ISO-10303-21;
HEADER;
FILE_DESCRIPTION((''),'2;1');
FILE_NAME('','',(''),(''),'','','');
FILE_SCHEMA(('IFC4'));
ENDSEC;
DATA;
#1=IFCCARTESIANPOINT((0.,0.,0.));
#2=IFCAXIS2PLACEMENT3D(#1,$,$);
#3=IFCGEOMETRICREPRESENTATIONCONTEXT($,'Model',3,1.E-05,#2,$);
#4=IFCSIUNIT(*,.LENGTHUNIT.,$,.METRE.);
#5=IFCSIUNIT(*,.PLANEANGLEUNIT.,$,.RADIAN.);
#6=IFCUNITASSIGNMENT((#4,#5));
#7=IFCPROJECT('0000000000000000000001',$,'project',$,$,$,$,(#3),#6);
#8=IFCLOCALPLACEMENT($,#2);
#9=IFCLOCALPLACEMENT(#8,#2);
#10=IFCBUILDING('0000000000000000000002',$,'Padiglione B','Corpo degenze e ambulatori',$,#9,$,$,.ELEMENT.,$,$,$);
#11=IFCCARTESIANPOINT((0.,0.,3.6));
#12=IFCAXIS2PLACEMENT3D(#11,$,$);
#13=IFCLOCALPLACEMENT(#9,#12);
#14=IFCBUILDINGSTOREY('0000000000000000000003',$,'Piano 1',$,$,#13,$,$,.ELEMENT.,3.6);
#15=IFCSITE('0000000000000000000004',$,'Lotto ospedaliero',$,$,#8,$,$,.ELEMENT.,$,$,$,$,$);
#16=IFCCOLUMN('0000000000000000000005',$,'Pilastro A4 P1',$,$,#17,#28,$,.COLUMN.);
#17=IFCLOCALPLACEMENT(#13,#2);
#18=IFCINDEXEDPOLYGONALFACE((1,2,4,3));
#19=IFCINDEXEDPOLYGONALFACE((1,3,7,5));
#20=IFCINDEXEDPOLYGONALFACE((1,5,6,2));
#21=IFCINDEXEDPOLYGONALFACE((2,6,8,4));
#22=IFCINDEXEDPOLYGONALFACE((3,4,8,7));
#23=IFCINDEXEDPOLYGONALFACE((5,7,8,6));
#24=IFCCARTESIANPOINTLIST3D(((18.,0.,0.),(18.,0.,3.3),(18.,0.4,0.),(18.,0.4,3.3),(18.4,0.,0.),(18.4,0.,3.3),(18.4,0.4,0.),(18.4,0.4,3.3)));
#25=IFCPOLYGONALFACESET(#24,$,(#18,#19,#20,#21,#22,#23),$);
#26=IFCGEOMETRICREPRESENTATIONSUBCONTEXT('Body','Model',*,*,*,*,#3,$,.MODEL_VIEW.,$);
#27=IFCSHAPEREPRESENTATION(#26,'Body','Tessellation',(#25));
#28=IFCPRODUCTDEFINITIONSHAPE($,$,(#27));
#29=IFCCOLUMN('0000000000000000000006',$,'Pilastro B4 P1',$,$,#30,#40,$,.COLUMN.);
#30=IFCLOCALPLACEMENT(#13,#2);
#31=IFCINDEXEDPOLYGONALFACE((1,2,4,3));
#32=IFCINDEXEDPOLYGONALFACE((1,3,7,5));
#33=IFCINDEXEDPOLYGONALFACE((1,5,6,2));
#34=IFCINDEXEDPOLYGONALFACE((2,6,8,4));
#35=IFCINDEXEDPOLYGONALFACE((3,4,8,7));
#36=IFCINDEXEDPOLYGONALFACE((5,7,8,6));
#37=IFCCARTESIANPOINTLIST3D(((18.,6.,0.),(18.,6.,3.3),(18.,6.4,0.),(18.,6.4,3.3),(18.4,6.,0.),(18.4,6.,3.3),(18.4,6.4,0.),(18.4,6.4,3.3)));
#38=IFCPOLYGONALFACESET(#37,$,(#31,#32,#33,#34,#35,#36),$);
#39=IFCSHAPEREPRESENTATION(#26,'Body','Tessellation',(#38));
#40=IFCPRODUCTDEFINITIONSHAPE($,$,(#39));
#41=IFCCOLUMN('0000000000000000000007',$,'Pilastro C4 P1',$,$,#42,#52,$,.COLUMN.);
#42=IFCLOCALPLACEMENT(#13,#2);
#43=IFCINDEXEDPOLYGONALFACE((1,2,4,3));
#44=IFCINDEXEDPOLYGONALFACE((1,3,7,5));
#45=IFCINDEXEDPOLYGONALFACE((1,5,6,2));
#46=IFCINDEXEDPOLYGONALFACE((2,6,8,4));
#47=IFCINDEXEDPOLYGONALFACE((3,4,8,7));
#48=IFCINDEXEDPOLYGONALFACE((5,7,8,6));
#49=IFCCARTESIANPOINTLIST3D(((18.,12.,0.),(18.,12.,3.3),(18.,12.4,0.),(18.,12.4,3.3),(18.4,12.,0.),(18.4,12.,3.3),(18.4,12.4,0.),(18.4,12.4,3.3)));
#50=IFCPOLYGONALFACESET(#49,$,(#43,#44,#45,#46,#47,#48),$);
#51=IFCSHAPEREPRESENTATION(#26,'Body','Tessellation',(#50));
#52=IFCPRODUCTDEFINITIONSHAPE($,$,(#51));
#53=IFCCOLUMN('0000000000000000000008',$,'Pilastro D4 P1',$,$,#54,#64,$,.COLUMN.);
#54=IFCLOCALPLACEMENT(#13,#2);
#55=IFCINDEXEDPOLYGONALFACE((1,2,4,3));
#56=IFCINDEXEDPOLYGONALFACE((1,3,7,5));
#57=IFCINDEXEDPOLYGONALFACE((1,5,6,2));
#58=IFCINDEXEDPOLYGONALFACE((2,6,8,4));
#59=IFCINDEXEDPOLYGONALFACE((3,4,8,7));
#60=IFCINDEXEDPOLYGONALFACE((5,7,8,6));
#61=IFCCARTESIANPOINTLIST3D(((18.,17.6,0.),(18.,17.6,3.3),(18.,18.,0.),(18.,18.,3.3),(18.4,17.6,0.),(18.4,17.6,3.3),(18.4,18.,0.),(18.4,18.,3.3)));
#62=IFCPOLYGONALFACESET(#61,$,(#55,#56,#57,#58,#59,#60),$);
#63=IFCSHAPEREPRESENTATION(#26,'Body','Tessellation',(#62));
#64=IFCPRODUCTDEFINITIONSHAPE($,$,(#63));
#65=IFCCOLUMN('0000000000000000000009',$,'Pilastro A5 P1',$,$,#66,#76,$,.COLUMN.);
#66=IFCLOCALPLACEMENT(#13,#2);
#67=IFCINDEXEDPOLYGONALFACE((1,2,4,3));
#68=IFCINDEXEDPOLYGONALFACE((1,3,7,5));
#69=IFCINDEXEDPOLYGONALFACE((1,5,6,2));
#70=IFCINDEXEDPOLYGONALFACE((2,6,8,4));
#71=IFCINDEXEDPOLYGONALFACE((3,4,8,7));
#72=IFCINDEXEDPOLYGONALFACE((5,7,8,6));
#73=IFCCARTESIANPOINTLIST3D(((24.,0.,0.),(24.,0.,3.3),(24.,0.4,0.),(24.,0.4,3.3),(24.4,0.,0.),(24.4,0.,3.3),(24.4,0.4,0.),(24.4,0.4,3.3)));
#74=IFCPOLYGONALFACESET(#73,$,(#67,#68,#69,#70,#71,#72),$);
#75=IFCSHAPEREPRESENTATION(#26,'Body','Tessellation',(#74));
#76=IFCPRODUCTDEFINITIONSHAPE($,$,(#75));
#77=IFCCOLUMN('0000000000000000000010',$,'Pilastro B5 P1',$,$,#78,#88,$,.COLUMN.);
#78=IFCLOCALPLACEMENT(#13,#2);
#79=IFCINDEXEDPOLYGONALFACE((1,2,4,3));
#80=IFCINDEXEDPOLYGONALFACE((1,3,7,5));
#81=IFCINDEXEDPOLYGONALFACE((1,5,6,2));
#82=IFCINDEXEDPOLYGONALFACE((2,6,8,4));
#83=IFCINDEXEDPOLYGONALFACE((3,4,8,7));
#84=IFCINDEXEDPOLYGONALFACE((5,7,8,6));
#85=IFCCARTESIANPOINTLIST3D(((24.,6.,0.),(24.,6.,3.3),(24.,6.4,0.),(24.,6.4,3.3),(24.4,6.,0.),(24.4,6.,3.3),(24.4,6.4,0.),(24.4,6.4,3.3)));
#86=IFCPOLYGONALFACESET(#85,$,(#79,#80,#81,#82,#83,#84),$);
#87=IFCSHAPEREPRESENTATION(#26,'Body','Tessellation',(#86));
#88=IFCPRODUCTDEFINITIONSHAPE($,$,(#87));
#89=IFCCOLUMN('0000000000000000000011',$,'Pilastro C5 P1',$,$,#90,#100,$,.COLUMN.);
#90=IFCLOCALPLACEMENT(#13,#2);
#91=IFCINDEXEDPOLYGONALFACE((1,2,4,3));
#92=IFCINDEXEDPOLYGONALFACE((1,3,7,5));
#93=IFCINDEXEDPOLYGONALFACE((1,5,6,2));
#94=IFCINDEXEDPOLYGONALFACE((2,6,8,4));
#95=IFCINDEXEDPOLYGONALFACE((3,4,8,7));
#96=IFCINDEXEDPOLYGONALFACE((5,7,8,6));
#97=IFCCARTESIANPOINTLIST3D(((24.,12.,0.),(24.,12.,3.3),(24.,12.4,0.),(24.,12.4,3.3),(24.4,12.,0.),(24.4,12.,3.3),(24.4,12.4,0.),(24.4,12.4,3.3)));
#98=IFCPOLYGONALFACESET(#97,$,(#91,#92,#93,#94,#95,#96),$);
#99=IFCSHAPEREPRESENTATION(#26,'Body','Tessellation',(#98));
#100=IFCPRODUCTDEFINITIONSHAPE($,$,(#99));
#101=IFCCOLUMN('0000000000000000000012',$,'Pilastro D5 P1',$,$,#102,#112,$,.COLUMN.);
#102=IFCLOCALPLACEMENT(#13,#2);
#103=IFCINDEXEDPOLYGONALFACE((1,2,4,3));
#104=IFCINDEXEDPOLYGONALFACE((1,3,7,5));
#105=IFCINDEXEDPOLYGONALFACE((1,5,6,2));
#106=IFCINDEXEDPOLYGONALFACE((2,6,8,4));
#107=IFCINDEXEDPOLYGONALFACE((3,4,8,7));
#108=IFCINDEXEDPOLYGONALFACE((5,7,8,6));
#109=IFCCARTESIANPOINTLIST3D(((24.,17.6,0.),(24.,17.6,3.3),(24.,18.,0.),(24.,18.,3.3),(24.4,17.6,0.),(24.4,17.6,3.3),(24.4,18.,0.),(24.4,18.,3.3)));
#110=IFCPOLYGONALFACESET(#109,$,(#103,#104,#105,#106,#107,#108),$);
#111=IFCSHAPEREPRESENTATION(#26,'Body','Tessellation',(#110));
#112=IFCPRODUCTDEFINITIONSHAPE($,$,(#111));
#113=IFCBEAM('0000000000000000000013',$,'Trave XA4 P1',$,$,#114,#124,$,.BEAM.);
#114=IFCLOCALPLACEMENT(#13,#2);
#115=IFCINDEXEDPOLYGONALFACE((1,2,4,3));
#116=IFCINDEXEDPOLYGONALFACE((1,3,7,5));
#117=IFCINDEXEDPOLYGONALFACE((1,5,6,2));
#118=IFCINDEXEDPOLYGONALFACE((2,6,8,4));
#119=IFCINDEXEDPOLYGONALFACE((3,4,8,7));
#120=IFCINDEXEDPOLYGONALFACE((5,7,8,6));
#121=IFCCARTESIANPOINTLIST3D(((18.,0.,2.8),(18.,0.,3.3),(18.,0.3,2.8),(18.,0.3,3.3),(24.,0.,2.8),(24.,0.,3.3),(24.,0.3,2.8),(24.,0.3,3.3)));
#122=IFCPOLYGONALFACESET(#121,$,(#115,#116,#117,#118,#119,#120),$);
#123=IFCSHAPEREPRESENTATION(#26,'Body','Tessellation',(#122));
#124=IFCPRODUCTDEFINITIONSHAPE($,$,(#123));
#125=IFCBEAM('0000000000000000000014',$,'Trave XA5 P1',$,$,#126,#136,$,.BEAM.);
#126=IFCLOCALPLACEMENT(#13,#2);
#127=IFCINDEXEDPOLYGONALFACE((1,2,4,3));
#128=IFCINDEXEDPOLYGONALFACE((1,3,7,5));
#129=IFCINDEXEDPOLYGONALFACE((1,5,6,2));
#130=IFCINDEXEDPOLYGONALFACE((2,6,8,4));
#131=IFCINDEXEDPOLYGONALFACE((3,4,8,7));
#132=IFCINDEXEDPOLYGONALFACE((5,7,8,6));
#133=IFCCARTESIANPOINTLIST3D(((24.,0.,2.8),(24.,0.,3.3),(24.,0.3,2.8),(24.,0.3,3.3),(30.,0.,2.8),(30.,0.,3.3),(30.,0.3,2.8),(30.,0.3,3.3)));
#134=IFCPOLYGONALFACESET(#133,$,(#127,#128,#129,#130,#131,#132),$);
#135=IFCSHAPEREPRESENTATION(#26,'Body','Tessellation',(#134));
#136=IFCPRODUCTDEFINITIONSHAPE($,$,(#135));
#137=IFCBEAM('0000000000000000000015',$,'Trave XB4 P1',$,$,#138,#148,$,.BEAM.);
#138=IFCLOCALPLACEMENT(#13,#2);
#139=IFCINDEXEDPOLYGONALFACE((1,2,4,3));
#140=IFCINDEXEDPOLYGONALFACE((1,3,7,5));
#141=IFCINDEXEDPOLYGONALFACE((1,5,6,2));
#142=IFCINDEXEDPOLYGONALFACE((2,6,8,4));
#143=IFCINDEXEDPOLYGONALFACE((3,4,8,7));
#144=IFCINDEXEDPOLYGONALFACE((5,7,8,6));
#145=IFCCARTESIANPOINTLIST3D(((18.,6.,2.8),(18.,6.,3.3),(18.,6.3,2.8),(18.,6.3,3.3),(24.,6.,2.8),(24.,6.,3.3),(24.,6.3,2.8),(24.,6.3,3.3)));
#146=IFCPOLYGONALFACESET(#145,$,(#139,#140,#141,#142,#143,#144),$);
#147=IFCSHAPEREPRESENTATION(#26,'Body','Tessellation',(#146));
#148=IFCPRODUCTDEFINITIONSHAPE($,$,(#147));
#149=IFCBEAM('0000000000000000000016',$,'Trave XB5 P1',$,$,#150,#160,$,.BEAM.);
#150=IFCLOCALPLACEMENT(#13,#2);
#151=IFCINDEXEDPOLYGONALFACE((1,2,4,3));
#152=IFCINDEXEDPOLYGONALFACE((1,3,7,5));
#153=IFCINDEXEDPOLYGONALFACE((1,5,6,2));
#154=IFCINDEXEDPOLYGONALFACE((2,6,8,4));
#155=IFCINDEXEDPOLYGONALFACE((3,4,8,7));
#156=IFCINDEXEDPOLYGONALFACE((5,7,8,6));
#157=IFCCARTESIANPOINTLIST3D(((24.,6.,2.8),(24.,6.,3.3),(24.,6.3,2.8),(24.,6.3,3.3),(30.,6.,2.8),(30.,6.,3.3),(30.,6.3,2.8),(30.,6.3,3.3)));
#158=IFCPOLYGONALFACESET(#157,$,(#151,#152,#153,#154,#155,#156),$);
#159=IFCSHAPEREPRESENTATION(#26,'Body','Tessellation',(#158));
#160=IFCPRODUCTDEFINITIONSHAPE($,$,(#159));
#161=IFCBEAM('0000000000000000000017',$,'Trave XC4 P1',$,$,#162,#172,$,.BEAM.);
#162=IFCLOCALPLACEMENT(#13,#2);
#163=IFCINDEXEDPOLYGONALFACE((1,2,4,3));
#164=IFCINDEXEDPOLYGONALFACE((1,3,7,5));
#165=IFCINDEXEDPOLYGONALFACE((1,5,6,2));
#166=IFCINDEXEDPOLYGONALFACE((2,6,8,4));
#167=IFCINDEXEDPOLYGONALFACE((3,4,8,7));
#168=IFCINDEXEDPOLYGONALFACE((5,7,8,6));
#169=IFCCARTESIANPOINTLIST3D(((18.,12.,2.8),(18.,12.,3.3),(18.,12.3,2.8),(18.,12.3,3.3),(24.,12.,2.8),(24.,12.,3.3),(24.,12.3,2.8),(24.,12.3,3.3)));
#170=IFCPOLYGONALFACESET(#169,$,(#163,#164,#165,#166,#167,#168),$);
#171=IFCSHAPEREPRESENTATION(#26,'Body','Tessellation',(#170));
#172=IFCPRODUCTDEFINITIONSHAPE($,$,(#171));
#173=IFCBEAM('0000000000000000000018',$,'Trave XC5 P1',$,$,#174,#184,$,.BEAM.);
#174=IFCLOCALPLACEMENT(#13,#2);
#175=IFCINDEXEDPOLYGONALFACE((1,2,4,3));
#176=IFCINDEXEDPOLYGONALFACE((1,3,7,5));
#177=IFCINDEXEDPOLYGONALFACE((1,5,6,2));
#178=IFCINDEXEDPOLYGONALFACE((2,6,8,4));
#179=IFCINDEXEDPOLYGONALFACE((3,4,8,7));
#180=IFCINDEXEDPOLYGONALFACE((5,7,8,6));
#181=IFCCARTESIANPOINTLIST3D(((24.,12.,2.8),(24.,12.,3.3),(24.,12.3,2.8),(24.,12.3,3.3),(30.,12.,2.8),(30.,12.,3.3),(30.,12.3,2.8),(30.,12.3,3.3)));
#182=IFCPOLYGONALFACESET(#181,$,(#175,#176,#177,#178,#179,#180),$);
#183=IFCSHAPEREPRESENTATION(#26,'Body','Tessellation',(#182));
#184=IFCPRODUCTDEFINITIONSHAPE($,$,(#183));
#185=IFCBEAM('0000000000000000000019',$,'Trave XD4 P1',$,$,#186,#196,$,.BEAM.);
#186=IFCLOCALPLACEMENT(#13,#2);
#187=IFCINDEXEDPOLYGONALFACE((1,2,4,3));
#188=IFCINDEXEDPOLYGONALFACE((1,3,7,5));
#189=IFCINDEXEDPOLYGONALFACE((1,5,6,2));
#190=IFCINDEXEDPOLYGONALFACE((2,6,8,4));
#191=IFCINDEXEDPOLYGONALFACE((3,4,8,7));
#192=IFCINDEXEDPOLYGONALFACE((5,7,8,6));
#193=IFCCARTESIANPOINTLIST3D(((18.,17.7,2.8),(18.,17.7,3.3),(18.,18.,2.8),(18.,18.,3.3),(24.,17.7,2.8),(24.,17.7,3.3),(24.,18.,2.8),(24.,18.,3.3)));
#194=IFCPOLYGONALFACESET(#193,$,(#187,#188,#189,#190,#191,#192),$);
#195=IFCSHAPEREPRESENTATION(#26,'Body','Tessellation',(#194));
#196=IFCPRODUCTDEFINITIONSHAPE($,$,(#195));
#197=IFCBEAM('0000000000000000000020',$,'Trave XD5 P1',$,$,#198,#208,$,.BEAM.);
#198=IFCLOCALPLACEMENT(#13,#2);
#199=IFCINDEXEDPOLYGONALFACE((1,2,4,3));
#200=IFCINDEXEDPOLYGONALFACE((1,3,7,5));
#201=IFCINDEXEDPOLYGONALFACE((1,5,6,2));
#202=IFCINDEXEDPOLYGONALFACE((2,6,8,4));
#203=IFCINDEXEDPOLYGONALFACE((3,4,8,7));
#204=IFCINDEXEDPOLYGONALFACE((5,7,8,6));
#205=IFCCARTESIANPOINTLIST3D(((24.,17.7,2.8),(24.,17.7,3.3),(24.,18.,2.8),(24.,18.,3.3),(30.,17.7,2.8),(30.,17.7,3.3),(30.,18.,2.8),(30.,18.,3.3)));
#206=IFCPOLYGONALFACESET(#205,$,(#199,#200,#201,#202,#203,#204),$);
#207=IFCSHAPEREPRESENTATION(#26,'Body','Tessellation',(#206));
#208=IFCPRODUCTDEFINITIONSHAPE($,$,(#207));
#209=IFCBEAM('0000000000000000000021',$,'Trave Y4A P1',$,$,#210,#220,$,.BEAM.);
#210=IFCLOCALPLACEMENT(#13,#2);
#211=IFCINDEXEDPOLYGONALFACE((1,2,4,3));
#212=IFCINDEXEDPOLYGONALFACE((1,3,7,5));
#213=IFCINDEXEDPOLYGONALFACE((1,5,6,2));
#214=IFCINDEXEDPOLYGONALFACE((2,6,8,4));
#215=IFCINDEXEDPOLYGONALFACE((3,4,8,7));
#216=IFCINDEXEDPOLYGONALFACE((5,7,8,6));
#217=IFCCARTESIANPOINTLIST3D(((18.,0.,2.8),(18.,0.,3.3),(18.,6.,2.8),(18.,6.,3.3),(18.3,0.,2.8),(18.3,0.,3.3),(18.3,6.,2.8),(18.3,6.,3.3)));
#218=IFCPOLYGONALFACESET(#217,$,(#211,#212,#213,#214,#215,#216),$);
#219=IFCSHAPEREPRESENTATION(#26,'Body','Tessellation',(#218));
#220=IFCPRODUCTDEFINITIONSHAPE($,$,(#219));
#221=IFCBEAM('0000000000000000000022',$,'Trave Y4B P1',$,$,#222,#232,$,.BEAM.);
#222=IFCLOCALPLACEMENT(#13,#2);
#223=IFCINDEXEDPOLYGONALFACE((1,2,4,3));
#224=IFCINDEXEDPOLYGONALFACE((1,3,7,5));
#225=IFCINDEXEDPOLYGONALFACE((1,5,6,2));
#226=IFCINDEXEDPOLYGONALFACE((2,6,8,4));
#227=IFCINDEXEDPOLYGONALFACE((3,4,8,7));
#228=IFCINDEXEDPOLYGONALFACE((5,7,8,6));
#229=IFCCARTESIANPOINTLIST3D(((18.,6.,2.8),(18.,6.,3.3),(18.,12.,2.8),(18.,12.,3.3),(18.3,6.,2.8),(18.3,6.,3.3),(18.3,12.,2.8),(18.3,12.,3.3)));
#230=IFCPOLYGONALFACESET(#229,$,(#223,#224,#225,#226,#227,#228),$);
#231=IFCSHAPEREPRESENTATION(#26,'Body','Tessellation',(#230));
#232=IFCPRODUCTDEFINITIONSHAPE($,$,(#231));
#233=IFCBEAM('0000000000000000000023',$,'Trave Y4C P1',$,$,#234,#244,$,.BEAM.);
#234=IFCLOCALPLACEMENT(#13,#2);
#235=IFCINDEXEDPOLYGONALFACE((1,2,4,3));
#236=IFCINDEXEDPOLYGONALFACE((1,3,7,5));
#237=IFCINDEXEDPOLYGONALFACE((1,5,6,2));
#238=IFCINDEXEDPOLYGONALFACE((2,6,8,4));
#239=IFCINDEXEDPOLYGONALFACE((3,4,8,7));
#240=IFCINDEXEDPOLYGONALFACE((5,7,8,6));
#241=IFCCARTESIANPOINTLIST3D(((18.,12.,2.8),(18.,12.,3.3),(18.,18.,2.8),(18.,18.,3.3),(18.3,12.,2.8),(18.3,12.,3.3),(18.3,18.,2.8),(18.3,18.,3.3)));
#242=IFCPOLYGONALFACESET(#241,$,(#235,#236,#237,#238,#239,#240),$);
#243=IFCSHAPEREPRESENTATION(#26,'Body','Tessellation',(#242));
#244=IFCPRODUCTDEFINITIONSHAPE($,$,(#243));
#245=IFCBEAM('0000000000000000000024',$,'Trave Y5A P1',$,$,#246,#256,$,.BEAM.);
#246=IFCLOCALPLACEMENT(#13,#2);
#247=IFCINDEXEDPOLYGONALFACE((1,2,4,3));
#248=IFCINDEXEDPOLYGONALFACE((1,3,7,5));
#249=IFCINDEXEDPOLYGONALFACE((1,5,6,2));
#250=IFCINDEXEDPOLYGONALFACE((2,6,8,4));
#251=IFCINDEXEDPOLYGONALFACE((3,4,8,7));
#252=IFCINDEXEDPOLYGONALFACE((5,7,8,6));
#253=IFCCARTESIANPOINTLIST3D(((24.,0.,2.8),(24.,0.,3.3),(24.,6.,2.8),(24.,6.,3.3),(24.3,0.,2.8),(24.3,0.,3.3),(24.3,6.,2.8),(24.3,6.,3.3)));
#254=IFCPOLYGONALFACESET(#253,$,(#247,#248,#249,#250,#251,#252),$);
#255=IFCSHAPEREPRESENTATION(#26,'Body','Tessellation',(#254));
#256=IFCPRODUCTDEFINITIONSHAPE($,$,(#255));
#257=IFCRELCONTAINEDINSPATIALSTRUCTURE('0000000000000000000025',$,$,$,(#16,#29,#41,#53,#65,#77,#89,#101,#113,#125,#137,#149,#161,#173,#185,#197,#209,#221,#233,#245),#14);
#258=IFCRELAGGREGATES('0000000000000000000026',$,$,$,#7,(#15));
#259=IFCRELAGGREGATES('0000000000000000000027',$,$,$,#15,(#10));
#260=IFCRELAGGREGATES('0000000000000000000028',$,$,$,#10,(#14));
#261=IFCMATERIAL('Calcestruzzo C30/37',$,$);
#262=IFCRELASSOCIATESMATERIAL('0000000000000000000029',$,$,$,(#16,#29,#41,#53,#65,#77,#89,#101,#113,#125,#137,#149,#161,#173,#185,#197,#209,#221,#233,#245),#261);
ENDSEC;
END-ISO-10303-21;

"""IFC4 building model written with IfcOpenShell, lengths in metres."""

from ifc_helpers import new_model, si_unit, frame, frame_2d, origin, place, context, subcontext, project, spatial, rectangle, extrude, material, element, save


model = new_model("IFC4")

# Units and contexts
model_context = context("Model", 3, precision=1e-05, world=origin())
body_context = subcontext(model_context, "Body", "Model", "MODEL_VIEW")
ifc_project = project(units=[si_unit("LENGTHUNIT", "METRE"), si_unit("PLANEANGLEUNIT", "RADIAN")], contexts=[model_context])

# Site, building, storey
site_placement = place(None, origin())
site = spatial("IfcSite", under=ifc_project, at=site_placement, Name="Lotto ospedaliero", CompositionType="ELEMENT")
building_placement = place(site_placement, origin())
building = spatial("IfcBuilding", under=site, at=building_placement, Name="Padiglione B", Description="Corpo degenze e ambulatori", CompositionType="ELEMENT")
storey_placement = place(building_placement, frame((0.0, 0.0, 3.6)))
storey = spatial("IfcBuildingStorey", under=building, at=storey_placement, Name="Piano 1", CompositionType="ELEMENT", Elevation=3.6)

# Columns
ifc_material_1 = material(Name="Calcestruzzo C30/37")
for number, where, name in (
    (1, (18.0, 0.0, 0.0), "Pilastro A4 P1"),
    (2, (18.0, 6.0, 0.0), "Pilastro B4 P1"),
    (3, (18.0, 12.0, 0.0), "Pilastro C4 P1"),
    (4, (18.0, 17.6, 0.0), "Pilastro D4 P1"),
    (5, (24.0, 0.0, 0.0), "Pilastro A5 P1"),
    (6, (24.0, 6.0, 0.0), "Pilastro B5 P1"),
    (7, (24.0, 12.0, 0.0), "Pilastro C5 P1"),
    (8, (24.0, 17.6, 0.0), "Pilastro D5 P1"),
):
    element("IfcColumn", number, at=place(storey_placement, frame(where)), inside=storey, material=ifc_material_1, Name=name, PredefinedType="COLUMN", context=body_context, shape_type="SweptSolid", body=[
        extrude(rectangle(XDim=0.4, YDim=0.4, at=frame_2d((0.2, 0.2))), origin(), (0.0, 0.0, 1.0), 3.3),
    ])

# Beams
for number, where, name in (
    (9, (18.0, 0.0, 2.8), "Trave XA4 P1"),
    (10, (24.0, 0.0, 2.8), "Trave XA5 P1"),
    (11, (18.0, 6.0, 2.8), "Trave XB4 P1"),
    (12, (24.0, 6.0, 2.8), "Trave XB5 P1"),
    (13, (18.0, 12.0, 2.8), "Trave XC4 P1"),
    (14, (24.0, 12.0, 2.8), "Trave XC5 P1"),
    (15, (18.0, 17.7, 2.8), "Trave XD4 P1"),
    (16, (24.0, 17.7, 2.8), "Trave XD5 P1"),
):
    element("IfcBeam", number, at=place(storey_placement, frame(where)), inside=storey, material=ifc_material_1, Name=name, PredefinedType="BEAM", context=body_context, shape_type="SweptSolid", body=[
        extrude(rectangle(XDim=6.0, YDim=0.3, at=frame_2d((3.0, 0.15))), origin(), (0.0, 0.0, 1.0), 0.5),
    ])
for number, where, name in (
    (17, (18.0, 0.0, 2.8), "Trave Y4A P1"),
    (18, (18.0, 6.0, 2.8), "Trave Y4B P1"),
    (19, (18.0, 12.0, 2.8), "Trave Y4C P1"),
    (20, (24.0, 0.0, 2.8), "Trave Y5A P1"),
):
    element("IfcBeam", number, at=place(storey_placement, frame(where)), inside=storey, material=ifc_material_1, Name=name, PredefinedType="BEAM", context=body_context, shape_type="SweptSolid", body=[
        extrude(rectangle(XDim=0.3, YDim=6.0, at=frame_2d((0.15, 3.0))), origin(), (0.0, 0.0, 1.0), 0.5),
    ])

save(model, "model.ifc")
